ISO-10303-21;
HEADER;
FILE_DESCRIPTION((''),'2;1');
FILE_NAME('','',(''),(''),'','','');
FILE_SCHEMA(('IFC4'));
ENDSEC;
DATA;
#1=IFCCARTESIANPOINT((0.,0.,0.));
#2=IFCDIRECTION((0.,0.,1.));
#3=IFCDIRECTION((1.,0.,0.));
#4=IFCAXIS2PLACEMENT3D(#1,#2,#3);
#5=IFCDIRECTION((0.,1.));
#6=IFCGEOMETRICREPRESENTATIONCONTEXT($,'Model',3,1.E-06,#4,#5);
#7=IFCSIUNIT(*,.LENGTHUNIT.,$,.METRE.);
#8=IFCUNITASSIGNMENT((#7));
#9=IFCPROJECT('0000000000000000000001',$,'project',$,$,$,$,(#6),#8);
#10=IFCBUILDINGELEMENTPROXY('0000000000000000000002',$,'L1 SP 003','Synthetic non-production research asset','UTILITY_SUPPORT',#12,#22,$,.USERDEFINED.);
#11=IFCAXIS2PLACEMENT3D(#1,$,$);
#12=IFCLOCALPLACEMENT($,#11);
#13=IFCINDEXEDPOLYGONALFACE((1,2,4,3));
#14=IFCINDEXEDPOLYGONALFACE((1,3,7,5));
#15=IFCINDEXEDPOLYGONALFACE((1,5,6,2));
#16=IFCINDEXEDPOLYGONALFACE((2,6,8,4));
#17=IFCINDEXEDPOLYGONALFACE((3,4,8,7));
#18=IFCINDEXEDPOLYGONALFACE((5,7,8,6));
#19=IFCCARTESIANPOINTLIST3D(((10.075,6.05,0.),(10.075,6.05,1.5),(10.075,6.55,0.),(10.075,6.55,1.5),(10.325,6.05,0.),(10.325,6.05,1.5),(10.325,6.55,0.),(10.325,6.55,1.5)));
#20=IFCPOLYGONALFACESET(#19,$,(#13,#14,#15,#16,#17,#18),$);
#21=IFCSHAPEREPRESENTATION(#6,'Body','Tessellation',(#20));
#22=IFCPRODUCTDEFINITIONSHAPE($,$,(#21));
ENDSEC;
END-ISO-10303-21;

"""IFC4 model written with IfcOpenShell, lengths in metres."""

from ifc_helpers import new_model, si_unit, direction, frame, origin_with_axes, origin_2d_with_axis, place, context, project, rectangle, extrude, element, save


model = new_model("IFC4")

# Units and contexts
model_context = context("Model", 3, precision=1e-06, world=origin_with_axes(), true_north=direction((0.0, 1.0)))
ifc_project = project(units=[si_unit("LENGTHUNIT", "METRE")], contexts=[model_context])

# Building element proxy
proxy_placement = place(None, frame((10.2, 6.3, 0.0), z_axis=(0.0, 0.0, 1.0), x_axis=(1.0, 0.0, 0.0)))
element("IfcBuildingElementProxy", 1, at=proxy_placement, Name="L1 SP 003", Description="Synthetic non-production research asset", ObjectType="UTILITY_SUPPORT", PredefinedType="USERDEFINED", context=model_context, shape_type="SweptSolid", body=[
    extrude(rectangle(XDim=0.25, YDim=0.5, at=origin_2d_with_axis()), origin_with_axes(), (0.0, 0.0, 1.0), 1.5),
])

save(model, "model.ifc")
